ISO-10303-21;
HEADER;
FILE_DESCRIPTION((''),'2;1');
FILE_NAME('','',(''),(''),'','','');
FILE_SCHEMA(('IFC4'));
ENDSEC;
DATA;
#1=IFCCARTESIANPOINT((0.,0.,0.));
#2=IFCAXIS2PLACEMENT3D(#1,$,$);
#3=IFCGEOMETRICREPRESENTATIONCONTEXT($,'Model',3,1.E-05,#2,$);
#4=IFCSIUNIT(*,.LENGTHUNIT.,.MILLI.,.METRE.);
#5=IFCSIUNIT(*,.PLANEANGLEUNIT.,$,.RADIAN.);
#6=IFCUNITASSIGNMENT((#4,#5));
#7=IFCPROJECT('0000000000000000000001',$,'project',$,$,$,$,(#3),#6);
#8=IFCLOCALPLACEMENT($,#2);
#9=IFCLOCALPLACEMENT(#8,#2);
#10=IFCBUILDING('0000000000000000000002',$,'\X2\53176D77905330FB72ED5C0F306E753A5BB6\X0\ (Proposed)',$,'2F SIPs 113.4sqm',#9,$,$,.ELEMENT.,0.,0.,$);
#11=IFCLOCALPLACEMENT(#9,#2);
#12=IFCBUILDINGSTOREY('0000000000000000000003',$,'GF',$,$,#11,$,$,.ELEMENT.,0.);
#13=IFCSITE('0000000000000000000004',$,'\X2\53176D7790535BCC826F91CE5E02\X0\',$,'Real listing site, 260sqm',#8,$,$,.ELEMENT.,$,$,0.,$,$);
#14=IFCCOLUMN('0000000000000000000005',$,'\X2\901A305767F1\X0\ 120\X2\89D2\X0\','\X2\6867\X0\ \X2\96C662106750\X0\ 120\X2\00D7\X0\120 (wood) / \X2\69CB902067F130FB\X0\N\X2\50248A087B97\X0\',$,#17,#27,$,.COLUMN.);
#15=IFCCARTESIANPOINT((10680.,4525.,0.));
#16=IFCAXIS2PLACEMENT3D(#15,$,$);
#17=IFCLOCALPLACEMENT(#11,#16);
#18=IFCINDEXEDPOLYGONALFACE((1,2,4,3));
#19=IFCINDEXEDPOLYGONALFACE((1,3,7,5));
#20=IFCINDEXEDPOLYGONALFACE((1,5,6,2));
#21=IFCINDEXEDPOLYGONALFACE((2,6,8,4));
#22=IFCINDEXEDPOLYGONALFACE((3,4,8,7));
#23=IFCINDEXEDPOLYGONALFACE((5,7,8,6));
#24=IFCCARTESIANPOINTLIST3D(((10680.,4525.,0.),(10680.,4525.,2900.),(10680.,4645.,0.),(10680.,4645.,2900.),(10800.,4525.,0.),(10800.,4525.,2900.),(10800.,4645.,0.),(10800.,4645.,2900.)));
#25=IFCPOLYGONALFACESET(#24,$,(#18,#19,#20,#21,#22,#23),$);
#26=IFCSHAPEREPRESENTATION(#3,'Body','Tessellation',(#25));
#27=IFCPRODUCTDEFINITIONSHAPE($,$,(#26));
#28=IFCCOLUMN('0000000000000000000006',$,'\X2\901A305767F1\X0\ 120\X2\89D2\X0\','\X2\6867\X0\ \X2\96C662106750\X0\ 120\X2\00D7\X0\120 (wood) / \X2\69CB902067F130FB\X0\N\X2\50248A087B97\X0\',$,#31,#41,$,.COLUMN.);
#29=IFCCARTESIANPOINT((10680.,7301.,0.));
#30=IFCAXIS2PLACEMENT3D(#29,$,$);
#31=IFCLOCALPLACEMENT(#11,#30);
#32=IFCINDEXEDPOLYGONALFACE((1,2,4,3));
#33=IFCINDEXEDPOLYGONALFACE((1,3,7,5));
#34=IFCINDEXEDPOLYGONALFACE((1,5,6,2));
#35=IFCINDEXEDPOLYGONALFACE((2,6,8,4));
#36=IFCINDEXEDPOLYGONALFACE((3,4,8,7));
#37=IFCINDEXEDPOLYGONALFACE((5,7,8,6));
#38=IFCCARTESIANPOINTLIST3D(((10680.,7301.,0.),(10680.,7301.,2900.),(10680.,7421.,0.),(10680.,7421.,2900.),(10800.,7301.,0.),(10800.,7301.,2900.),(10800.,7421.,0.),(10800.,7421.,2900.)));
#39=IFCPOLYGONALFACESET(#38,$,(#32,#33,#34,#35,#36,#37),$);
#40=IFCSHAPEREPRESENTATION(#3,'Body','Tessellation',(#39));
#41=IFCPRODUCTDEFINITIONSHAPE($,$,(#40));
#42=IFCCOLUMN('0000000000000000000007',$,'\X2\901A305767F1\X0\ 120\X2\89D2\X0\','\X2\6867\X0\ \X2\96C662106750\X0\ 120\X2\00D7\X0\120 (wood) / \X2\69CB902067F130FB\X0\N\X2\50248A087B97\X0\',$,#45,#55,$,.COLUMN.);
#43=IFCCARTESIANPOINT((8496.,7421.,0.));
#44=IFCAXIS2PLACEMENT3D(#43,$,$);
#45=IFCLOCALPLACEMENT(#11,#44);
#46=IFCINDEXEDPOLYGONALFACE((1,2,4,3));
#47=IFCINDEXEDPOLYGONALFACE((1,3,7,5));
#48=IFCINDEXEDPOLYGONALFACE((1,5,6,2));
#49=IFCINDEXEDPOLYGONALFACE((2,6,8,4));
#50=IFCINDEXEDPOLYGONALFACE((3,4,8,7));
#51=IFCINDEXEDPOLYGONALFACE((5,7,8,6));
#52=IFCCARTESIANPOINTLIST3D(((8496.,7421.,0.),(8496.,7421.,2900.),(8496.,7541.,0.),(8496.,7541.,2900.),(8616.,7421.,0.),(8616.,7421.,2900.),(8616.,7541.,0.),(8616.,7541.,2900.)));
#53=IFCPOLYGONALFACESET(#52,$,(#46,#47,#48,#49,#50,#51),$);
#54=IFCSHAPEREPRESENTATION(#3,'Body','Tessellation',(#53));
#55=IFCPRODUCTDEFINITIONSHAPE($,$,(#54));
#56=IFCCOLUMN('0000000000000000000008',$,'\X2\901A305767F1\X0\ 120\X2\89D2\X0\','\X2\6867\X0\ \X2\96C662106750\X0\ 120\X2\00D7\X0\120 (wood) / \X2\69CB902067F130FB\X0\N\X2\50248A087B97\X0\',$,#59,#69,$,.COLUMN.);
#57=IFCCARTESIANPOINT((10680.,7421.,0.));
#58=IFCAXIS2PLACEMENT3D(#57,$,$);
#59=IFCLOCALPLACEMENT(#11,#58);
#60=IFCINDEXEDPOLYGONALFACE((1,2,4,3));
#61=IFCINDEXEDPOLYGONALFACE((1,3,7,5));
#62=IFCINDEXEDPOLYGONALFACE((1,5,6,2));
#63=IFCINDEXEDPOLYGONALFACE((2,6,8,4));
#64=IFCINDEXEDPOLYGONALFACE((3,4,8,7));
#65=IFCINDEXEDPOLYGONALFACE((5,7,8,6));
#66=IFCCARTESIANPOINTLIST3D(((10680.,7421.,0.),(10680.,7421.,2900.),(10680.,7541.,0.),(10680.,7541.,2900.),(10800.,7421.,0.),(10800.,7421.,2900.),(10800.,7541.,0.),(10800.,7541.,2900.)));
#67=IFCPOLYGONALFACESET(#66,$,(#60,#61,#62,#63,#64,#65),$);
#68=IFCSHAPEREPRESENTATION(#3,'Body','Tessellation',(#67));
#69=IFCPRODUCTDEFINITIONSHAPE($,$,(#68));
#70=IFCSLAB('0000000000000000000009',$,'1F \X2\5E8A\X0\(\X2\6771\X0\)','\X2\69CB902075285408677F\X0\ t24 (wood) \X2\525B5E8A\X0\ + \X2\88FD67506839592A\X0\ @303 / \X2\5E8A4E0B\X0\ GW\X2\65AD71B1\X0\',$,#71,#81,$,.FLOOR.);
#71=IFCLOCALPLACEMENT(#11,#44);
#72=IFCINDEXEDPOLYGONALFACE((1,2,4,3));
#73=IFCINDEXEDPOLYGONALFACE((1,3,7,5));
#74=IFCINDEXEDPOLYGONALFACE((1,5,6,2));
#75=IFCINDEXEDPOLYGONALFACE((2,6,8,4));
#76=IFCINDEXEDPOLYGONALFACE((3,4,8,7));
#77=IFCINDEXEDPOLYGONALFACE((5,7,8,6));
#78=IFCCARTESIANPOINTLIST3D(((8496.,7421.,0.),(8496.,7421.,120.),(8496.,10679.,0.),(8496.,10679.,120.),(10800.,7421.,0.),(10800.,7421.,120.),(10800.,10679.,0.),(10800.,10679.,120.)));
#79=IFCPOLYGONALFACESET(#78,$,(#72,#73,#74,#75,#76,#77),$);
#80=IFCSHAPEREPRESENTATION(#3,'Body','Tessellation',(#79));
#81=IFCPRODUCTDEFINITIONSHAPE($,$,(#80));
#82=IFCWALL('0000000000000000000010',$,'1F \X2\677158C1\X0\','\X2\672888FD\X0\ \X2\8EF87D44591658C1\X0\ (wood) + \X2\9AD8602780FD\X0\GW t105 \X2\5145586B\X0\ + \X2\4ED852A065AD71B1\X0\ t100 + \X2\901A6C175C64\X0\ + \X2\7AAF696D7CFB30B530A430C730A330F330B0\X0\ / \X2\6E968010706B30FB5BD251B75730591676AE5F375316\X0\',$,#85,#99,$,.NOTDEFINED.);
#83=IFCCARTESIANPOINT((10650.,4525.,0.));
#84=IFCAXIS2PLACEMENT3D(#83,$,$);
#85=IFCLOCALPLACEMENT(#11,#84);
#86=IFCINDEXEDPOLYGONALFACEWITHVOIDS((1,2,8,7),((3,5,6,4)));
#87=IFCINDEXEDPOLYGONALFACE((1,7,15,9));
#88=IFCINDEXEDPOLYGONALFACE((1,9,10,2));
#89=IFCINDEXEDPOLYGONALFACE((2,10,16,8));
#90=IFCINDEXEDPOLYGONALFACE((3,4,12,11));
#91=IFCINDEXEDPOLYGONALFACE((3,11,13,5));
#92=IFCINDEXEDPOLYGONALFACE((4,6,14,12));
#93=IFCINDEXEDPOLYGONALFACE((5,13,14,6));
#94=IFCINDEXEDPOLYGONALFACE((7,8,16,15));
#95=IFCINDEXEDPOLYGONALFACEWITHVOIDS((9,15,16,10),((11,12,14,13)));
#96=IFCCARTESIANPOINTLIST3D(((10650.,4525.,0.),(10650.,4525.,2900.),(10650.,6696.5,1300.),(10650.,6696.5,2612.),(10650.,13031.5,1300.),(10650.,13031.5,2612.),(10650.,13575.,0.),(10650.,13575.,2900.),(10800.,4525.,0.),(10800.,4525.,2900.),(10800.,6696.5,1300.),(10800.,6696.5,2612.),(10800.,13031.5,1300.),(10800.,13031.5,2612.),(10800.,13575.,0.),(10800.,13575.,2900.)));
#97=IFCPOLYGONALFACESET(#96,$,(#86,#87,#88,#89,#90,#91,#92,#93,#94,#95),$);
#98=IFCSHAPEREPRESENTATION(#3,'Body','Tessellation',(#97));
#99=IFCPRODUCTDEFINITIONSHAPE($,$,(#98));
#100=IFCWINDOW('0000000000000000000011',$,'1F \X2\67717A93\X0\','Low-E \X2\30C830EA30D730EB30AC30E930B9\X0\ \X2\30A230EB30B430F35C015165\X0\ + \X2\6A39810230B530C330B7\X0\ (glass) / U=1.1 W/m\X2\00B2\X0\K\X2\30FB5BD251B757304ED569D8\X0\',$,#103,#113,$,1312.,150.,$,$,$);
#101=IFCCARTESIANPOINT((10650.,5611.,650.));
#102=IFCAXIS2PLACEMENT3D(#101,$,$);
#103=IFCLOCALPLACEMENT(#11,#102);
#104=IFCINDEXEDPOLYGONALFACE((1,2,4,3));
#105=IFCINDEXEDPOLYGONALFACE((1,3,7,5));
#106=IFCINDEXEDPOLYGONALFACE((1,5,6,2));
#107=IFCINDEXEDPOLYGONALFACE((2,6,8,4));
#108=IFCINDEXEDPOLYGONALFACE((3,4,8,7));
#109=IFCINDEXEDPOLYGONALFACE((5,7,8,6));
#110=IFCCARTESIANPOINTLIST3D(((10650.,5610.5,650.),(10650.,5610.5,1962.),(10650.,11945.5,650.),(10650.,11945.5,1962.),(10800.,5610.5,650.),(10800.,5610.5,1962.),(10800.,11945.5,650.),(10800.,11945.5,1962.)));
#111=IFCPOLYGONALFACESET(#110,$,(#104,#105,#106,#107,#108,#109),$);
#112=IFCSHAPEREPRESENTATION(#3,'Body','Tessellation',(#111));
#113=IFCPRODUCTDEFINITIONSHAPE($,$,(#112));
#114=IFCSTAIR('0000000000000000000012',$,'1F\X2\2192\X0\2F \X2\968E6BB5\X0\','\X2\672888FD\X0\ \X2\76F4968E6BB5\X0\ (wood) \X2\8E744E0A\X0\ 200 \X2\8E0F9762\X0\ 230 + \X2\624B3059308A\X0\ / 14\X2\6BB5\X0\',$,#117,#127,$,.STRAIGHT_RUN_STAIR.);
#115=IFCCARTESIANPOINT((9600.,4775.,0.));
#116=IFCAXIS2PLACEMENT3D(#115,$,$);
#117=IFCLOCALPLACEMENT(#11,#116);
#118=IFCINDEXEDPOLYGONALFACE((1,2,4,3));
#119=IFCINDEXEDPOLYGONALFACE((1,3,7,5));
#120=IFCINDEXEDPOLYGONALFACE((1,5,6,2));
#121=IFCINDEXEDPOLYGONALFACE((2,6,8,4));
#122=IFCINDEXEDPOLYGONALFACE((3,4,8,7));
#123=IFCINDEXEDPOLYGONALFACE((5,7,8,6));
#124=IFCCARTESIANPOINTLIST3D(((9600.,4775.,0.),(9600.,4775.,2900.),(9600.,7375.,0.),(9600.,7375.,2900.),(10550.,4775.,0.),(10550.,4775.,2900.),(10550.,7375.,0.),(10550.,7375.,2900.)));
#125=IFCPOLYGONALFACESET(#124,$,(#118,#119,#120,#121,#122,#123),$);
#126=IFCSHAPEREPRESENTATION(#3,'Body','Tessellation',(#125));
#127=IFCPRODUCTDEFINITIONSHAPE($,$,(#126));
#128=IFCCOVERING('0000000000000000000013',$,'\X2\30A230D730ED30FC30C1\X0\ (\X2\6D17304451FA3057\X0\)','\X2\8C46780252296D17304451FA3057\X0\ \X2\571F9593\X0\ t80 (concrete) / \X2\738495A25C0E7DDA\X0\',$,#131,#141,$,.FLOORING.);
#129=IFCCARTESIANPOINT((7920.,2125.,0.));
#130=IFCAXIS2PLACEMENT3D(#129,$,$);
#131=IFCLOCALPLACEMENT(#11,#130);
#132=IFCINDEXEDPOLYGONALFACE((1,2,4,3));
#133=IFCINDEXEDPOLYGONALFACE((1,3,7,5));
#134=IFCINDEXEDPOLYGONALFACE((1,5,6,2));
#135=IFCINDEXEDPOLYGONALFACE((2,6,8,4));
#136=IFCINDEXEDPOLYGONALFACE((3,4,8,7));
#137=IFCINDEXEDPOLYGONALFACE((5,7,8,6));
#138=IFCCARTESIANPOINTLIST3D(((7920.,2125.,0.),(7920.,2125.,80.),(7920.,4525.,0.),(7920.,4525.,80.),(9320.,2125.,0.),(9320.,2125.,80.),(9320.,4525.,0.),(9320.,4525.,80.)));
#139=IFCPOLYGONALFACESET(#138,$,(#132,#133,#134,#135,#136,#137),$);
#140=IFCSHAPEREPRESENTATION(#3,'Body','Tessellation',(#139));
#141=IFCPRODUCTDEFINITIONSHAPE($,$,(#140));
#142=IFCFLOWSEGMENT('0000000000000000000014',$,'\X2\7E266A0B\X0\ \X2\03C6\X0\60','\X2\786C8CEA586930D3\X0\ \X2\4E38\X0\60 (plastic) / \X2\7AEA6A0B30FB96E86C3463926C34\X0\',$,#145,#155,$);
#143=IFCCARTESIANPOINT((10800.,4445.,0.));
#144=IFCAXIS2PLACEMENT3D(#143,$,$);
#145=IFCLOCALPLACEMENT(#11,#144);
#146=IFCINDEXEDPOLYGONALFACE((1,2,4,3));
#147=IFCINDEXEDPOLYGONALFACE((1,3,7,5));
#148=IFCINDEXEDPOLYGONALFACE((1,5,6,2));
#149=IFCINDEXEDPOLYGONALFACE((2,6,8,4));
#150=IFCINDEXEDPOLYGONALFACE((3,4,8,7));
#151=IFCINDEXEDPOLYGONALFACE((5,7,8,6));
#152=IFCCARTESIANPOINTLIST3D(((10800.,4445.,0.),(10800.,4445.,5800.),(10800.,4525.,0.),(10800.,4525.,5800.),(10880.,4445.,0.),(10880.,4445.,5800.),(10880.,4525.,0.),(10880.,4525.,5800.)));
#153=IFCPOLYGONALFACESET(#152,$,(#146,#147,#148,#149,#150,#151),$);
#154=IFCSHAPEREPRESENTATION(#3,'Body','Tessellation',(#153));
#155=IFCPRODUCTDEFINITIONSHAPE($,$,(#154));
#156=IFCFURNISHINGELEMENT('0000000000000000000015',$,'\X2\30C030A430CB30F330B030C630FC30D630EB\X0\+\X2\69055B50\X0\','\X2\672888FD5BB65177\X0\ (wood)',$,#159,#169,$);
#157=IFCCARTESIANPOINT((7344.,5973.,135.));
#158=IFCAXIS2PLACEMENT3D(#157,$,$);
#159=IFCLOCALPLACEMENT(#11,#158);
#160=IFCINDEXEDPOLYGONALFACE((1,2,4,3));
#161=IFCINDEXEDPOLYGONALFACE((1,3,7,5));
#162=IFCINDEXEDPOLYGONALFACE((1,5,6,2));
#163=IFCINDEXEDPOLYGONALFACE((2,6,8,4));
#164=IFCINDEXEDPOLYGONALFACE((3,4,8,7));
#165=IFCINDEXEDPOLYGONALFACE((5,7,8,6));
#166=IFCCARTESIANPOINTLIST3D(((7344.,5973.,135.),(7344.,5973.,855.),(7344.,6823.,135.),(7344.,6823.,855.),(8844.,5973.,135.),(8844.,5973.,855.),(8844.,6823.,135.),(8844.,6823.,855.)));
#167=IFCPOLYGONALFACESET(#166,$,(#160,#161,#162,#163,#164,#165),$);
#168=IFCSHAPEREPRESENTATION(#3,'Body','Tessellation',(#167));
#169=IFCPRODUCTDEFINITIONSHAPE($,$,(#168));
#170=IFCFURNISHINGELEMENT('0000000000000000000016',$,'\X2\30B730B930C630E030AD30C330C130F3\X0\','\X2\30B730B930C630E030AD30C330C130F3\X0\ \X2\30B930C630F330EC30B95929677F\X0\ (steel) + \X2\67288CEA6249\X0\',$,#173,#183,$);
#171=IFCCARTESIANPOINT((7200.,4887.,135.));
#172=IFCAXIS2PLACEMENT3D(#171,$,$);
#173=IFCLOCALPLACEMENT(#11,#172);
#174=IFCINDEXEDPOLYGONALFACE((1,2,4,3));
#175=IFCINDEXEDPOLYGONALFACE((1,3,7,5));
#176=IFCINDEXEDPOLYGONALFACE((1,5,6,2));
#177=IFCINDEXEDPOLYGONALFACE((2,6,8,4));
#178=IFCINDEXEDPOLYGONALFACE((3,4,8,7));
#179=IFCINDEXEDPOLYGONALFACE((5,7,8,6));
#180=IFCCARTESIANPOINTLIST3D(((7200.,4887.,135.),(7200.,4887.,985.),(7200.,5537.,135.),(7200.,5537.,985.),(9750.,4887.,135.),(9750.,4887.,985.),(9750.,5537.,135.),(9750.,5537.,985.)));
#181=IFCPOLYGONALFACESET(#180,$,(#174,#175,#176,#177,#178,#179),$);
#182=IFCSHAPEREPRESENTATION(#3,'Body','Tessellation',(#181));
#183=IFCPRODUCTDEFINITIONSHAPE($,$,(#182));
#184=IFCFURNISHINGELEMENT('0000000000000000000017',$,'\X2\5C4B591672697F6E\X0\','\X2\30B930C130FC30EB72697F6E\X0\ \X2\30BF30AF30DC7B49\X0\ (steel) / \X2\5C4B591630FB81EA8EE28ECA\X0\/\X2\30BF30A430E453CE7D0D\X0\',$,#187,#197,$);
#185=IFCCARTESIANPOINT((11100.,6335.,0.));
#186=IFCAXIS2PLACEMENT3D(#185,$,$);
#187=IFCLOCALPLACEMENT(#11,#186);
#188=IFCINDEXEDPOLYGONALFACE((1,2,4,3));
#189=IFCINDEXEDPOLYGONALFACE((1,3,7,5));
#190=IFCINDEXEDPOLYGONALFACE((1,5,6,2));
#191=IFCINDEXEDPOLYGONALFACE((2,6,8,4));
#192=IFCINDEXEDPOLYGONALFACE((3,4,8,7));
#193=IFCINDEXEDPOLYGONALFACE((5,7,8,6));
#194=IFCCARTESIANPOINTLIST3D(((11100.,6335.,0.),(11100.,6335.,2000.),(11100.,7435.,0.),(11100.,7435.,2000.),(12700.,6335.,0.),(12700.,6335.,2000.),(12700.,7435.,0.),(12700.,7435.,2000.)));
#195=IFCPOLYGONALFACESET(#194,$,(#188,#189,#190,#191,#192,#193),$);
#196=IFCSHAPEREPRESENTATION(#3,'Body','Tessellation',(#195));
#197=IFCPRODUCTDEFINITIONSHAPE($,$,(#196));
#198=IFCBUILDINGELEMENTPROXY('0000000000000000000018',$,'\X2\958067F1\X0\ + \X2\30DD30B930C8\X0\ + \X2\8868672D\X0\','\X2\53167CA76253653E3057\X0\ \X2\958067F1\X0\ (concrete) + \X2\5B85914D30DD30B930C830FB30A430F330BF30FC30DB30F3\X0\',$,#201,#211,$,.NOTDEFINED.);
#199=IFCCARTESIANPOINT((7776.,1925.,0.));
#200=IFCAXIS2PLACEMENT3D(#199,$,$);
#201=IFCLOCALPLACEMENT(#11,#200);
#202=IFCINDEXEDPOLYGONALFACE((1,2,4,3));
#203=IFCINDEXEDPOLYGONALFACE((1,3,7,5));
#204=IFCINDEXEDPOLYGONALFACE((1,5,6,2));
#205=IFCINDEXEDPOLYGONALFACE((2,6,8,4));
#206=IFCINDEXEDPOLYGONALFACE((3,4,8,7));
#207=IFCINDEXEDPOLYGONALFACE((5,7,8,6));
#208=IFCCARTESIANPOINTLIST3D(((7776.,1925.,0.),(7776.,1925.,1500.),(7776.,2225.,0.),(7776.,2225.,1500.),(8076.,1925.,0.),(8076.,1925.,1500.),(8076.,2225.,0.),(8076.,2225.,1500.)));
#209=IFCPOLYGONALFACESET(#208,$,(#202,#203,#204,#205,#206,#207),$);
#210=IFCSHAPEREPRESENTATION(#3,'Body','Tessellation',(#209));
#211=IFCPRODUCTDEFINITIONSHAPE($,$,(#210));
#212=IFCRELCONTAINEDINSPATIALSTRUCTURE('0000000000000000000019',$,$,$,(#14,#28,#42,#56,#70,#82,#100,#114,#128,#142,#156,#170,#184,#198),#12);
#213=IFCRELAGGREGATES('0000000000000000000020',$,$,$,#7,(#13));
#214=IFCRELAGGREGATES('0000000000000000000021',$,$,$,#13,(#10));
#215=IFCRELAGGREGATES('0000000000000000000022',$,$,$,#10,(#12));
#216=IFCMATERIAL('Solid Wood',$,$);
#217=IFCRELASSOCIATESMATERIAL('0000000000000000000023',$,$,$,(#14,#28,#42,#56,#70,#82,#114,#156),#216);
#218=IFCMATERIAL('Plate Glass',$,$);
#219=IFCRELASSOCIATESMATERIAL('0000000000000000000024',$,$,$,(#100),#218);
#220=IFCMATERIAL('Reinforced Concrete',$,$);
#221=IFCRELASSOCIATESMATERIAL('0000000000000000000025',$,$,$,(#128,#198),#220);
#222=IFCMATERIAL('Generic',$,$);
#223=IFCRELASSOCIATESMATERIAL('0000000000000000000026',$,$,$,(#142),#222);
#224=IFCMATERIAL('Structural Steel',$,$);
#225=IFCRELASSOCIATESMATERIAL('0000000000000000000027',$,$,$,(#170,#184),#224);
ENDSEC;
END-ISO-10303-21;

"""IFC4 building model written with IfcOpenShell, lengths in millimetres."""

from ifc_helpers import new_model, si_unit, frame, frame_2d, origin, place, context, project, spatial, rectangle, extrude, material, element, fill, save


model = new_model("IFC4")

# Units and contexts
model_context = context("Model", 3, precision=1e-05, world=origin())
ifc_project = project(units=[si_unit("LENGTHUNIT", "METRE", prefix="MILLI"), si_unit("PLANEANGLEUNIT", "RADIAN")], contexts=[model_context])

# Site, building, storey
site_placement = place(None, origin())
site = spatial("IfcSite", under=ifc_project, at=site_placement, Name="北海道富良野市", ObjectType="Real listing site, 260sqm", CompositionType="ELEMENT", RefElevation=0.0)
building_placement = place(site_placement, origin())
building = spatial("IfcBuilding", under=site, at=building_placement, Name="北海道・狭小の町家 (Proposed)", ObjectType="2F SIPs 113.4sqm", CompositionType="ELEMENT", ElevationOfRefHeight=0.0, ElevationOfTerrain=0.0)
storey_placement = place(building_placement, origin())
storey = spatial("IfcBuildingStorey", under=building, at=storey_placement, Name="GF", CompositionType="ELEMENT", Elevation=0.0)

# Columns
ifc_material_1 = material(Name="Solid Wood")
column_1_placement = place(storey_placement, frame((10680.0, 4525.0, 0.0)))
element("IfcColumn", 1, at=column_1_placement, inside=storey, material=ifc_material_1, Name="通し柱 120角", Description="桧 集成材 120×120 (wood) / 構造柱・N値計算", PredefinedType="COLUMN", context=model_context, shape_type="SweptSolid", body=[
    extrude(rectangle(XDim=120.0, YDim=120.0, at=frame_2d((60.0, 60.0))), frame((10680.0, 4525.0, 0.0)), (0.0, 0.0, 1.0), 2900.0),
])
column_2_placement = place(storey_placement, frame((10680.0, 7301.0, 0.0)))
element("IfcColumn", 2, at=column_2_placement, inside=storey, material=ifc_material_1, Name="通し柱 120角", Description="桧 集成材 120×120 (wood) / 構造柱・N値計算", PredefinedType="COLUMN", context=model_context, shape_type="SweptSolid", body=[
    extrude(rectangle(XDim=120.0, YDim=120.0, at=frame_2d((60.0, 60.0))), frame((10680.0, 7301.0, 0.0)), (0.0, 0.0, 1.0), 2900.0),
])
column_3_placement = place(storey_placement, frame((8496.0, 7421.0, 0.0)))
element("IfcColumn", 3, at=column_3_placement, inside=storey, material=ifc_material_1, Name="通し柱 120角", Description="桧 集成材 120×120 (wood) / 構造柱・N値計算", PredefinedType="COLUMN", context=model_context, shape_type="SweptSolid", body=[
    extrude(rectangle(XDim=120.0, YDim=120.0, at=frame_2d((60.0, 60.0))), frame((8496.0, 7421.0, 0.0)), (0.0, 0.0, 1.0), 2900.0),
])
column_4_placement = place(storey_placement, frame((10680.0, 7421.0, 0.0)))
element("IfcColumn", 4, at=column_4_placement, inside=storey, material=ifc_material_1, Name="通し柱 120角", Description="桧 集成材 120×120 (wood) / 構造柱・N値計算", PredefinedType="COLUMN", context=model_context, shape_type="SweptSolid", body=[
    extrude(rectangle(XDim=120.0, YDim=120.0, at=frame_2d((60.0, 60.0))), frame((10680.0, 7421.0, 0.0)), (0.0, 0.0, 1.0), 2900.0),
])

# Slab
slab_placement = place(storey_placement, frame((8496.0, 7421.0, 0.0)))
element("IfcSlab", 5, at=slab_placement, inside=storey, material=ifc_material_1, Name="1F 床(東)", Description="構造用合板 t24 (wood) 剛床 + 製材根太 @303 / 床下 GW断熱", PredefinedType="FLOOR", context=model_context, shape_type="SweptSolid", body=[
    extrude(rectangle(XDim=2304.0, YDim=3258.0, at=frame_2d((1152.0, 1629.0))), frame((8496.0, 7421.0, 0.0)), (0.0, 0.0, 1.0), 120.0),
])

# Wall, opening, window
wall_1_placement = place(storey_placement, frame((10650.0, 4525.0, 0.0)))
wall_1 = element("IfcWall", 6, at=wall_1_placement, inside=storey, material=ifc_material_1, Name="1F 東壁", Description="木製 軸組外壁 (wood) + 高性能GW t105 充填 + 付加断熱 t100 + 通気層 + 窯業系サイディング / 準耐火・寒冷地外皮強化", PredefinedType="NOTDEFINED", context=model_context, shape_type="SweptSolid", body=[
    extrude(rectangle(XDim=150.0, YDim=9050.0, at=frame_2d((75.0, 4525.0))), frame((10650.0, 4525.0, 0.0)), (0.0, 0.0, 1.0), 2900.0),
])
opening_placement = place(storey_placement, frame((10650.0, 5611.0, 650.0)))
opening = element("IfcOpeningElement", 7, at=opening_placement, cuts=wall_1, PredefinedType="NOTDEFINED", context=model_context, shape_type="SweptSolid", body=[
    extrude(rectangle(XDim=150.0, YDim=6335.0, at=frame_2d((75.0, 3167.0))), frame((10650.0, 5611.0, 650.0)), (0.0, 0.0, 1.0), 1312.0),
])
ifc_material_2 = material(Name="Plate Glass")
window_placement = place(storey_placement, frame((10650.0, 5611.0, 650.0)))
window = element("IfcWindow", 8, at=window_placement, inside=storey, material=ifc_material_2, Name="1F 東窓", Description="Low-E トリプルガラス アルゴン封入 + 樹脂サッシ (glass) / U=1.1 W/m²K・寒冷地仕様", OverallHeight=1312.0, OverallWidth=150.0, context=model_context, shape_type="SweptSolid", body=[
    extrude(rectangle(XDim=150.0, YDim=6335.0, at=frame_2d((75.0, 3167.0))), frame((10650.0, 5611.0, 650.0)), (0.0, 0.0, 1.0), 1312.0),
])
fill(opening, window)

# Stair
stair_placement = place(storey_placement, frame((9600.0, 4775.0, 0.0)))
element("IfcStair", 9, at=stair_placement, inside=storey, material=ifc_material_1, Name="1F→2F 階段", Description="木製 直階段 (wood) 蹴上 200 踏面 230 + 手すり / 14段", PredefinedType="STRAIGHT_RUN_STAIR", context=model_context, shape_type="SweptSolid", body=[
    extrude(rectangle(XDim=950.0, YDim=2600.0, at=frame_2d((475.0, 1300.0))), frame((9600.0, 4775.0, 0.0)), (0.0, 0.0, 1.0), 2900.0),
])

# Covering
ifc_material_3 = material(Name="Reinforced Concrete")
covering_placement = place(storey_placement, frame((7920.0, 2125.0, 0.0)))
element("IfcCovering", 10, at=covering_placement, inside=storey, material=ifc_material_3, Name="アプローチ (洗い出し)", Description="豆砂利洗い出し 土間 t80 (concrete) / 玄関導線", PredefinedType="FLOORING", context=model_context, shape_type="SweptSolid", body=[
    extrude(rectangle(XDim=1400.0, YDim=2400.0, at=frame_2d((700.0, 1200.0))), frame((7920.0, 2125.0, 0.0)), (0.0, 0.0, 1.0), 80.0),
])

# Flow segment
ifc_material_4 = material(Name="Generic")
flow_segment_placement = place(storey_placement, frame((10800.0, 4445.0, 0.0)))
element("IfcFlowSegment", 11, at=flow_segment_placement, inside=storey, material=ifc_material_4, Name="縦樋 φ60", Description="硬質塩ビ 丸60 (plastic) / 竪樋・雨水排水", context=model_context, shape_type="SweptSolid", body=[
    extrude(rectangle(XDim=80.0, YDim=80.0, at=frame_2d((40.0, 40.0))), frame((10800.0, 4445.0, 0.0)), (0.0, 0.0, 1.0), 5800.0),
])

# Furnishing elements
furnishing_1_placement = place(storey_placement, frame((7344.0, 5973.0, 135.0)))
element("IfcFurnishingElement", 12, at=furnishing_1_placement, inside=storey, material=ifc_material_1, Name="ダイニングテーブル+椅子", Description="木製家具 (wood)", context=model_context, shape_type="SweptSolid", body=[
    extrude(rectangle(XDim=1500.0, YDim=850.0, at=frame_2d((750.0, 425.0))), frame((7344.0, 5973.0, 135.0)), (0.0, 0.0, 1.0), 720.0),
])
ifc_material_5 = material(Name="Structural Steel")
furnishing_2_placement = place(storey_placement, frame((7200.0, 4887.0, 135.0)))
element("IfcFurnishingElement", 13, at=furnishing_2_placement, inside=storey, material=ifc_material_5, Name="システムキッチン", Description="システムキッチン ステンレス天板 (steel) + 木質扉", context=model_context, shape_type="SweptSolid", body=[
    extrude(rectangle(XDim=2550.0, YDim=650.0, at=frame_2d((1275.0, 325.0))), frame((7200.0, 4887.0, 135.0)), (0.0, 0.0, 1.0), 850.0),
])
furnishing_3_placement = place(storey_placement, frame((11100.0, 6335.0, 0.0)))
element("IfcFurnishingElement", 14, at=furnishing_3_placement, inside=storey, material=ifc_material_5, Name="屋外物置", Description="スチール物置 タクボ等 (steel) / 屋外・自転車/タイヤ収納", context=model_context, shape_type="SweptSolid", body=[
    extrude(rectangle(XDim=1600.0, YDim=1100.0, at=frame_2d((800.0, 550.0))), frame((11100.0, 6335.0, 0.0)), (0.0, 0.0, 1.0), 2000.0),
])

# Building element proxy
proxy_placement = place(storey_placement, frame((7776.0, 1925.0, 0.0)))
element("IfcBuildingElementProxy", 15, at=proxy_placement, inside=storey, material=ifc_material_3, Name="門柱 + ポスト + 表札", Description="化粧打放し 門柱 (concrete) + 宅配ポスト・インターホン", PredefinedType="NOTDEFINED", context=model_context, shape_type="SweptSolid", body=[
    extrude(rectangle(XDim=300.0, YDim=300.0, at=frame_2d((150.0, 150.0))), frame((7776.0, 1925.0, 0.0)), (0.0, 0.0, 1.0), 1500.0),
])

save(model, "model.ifc")
